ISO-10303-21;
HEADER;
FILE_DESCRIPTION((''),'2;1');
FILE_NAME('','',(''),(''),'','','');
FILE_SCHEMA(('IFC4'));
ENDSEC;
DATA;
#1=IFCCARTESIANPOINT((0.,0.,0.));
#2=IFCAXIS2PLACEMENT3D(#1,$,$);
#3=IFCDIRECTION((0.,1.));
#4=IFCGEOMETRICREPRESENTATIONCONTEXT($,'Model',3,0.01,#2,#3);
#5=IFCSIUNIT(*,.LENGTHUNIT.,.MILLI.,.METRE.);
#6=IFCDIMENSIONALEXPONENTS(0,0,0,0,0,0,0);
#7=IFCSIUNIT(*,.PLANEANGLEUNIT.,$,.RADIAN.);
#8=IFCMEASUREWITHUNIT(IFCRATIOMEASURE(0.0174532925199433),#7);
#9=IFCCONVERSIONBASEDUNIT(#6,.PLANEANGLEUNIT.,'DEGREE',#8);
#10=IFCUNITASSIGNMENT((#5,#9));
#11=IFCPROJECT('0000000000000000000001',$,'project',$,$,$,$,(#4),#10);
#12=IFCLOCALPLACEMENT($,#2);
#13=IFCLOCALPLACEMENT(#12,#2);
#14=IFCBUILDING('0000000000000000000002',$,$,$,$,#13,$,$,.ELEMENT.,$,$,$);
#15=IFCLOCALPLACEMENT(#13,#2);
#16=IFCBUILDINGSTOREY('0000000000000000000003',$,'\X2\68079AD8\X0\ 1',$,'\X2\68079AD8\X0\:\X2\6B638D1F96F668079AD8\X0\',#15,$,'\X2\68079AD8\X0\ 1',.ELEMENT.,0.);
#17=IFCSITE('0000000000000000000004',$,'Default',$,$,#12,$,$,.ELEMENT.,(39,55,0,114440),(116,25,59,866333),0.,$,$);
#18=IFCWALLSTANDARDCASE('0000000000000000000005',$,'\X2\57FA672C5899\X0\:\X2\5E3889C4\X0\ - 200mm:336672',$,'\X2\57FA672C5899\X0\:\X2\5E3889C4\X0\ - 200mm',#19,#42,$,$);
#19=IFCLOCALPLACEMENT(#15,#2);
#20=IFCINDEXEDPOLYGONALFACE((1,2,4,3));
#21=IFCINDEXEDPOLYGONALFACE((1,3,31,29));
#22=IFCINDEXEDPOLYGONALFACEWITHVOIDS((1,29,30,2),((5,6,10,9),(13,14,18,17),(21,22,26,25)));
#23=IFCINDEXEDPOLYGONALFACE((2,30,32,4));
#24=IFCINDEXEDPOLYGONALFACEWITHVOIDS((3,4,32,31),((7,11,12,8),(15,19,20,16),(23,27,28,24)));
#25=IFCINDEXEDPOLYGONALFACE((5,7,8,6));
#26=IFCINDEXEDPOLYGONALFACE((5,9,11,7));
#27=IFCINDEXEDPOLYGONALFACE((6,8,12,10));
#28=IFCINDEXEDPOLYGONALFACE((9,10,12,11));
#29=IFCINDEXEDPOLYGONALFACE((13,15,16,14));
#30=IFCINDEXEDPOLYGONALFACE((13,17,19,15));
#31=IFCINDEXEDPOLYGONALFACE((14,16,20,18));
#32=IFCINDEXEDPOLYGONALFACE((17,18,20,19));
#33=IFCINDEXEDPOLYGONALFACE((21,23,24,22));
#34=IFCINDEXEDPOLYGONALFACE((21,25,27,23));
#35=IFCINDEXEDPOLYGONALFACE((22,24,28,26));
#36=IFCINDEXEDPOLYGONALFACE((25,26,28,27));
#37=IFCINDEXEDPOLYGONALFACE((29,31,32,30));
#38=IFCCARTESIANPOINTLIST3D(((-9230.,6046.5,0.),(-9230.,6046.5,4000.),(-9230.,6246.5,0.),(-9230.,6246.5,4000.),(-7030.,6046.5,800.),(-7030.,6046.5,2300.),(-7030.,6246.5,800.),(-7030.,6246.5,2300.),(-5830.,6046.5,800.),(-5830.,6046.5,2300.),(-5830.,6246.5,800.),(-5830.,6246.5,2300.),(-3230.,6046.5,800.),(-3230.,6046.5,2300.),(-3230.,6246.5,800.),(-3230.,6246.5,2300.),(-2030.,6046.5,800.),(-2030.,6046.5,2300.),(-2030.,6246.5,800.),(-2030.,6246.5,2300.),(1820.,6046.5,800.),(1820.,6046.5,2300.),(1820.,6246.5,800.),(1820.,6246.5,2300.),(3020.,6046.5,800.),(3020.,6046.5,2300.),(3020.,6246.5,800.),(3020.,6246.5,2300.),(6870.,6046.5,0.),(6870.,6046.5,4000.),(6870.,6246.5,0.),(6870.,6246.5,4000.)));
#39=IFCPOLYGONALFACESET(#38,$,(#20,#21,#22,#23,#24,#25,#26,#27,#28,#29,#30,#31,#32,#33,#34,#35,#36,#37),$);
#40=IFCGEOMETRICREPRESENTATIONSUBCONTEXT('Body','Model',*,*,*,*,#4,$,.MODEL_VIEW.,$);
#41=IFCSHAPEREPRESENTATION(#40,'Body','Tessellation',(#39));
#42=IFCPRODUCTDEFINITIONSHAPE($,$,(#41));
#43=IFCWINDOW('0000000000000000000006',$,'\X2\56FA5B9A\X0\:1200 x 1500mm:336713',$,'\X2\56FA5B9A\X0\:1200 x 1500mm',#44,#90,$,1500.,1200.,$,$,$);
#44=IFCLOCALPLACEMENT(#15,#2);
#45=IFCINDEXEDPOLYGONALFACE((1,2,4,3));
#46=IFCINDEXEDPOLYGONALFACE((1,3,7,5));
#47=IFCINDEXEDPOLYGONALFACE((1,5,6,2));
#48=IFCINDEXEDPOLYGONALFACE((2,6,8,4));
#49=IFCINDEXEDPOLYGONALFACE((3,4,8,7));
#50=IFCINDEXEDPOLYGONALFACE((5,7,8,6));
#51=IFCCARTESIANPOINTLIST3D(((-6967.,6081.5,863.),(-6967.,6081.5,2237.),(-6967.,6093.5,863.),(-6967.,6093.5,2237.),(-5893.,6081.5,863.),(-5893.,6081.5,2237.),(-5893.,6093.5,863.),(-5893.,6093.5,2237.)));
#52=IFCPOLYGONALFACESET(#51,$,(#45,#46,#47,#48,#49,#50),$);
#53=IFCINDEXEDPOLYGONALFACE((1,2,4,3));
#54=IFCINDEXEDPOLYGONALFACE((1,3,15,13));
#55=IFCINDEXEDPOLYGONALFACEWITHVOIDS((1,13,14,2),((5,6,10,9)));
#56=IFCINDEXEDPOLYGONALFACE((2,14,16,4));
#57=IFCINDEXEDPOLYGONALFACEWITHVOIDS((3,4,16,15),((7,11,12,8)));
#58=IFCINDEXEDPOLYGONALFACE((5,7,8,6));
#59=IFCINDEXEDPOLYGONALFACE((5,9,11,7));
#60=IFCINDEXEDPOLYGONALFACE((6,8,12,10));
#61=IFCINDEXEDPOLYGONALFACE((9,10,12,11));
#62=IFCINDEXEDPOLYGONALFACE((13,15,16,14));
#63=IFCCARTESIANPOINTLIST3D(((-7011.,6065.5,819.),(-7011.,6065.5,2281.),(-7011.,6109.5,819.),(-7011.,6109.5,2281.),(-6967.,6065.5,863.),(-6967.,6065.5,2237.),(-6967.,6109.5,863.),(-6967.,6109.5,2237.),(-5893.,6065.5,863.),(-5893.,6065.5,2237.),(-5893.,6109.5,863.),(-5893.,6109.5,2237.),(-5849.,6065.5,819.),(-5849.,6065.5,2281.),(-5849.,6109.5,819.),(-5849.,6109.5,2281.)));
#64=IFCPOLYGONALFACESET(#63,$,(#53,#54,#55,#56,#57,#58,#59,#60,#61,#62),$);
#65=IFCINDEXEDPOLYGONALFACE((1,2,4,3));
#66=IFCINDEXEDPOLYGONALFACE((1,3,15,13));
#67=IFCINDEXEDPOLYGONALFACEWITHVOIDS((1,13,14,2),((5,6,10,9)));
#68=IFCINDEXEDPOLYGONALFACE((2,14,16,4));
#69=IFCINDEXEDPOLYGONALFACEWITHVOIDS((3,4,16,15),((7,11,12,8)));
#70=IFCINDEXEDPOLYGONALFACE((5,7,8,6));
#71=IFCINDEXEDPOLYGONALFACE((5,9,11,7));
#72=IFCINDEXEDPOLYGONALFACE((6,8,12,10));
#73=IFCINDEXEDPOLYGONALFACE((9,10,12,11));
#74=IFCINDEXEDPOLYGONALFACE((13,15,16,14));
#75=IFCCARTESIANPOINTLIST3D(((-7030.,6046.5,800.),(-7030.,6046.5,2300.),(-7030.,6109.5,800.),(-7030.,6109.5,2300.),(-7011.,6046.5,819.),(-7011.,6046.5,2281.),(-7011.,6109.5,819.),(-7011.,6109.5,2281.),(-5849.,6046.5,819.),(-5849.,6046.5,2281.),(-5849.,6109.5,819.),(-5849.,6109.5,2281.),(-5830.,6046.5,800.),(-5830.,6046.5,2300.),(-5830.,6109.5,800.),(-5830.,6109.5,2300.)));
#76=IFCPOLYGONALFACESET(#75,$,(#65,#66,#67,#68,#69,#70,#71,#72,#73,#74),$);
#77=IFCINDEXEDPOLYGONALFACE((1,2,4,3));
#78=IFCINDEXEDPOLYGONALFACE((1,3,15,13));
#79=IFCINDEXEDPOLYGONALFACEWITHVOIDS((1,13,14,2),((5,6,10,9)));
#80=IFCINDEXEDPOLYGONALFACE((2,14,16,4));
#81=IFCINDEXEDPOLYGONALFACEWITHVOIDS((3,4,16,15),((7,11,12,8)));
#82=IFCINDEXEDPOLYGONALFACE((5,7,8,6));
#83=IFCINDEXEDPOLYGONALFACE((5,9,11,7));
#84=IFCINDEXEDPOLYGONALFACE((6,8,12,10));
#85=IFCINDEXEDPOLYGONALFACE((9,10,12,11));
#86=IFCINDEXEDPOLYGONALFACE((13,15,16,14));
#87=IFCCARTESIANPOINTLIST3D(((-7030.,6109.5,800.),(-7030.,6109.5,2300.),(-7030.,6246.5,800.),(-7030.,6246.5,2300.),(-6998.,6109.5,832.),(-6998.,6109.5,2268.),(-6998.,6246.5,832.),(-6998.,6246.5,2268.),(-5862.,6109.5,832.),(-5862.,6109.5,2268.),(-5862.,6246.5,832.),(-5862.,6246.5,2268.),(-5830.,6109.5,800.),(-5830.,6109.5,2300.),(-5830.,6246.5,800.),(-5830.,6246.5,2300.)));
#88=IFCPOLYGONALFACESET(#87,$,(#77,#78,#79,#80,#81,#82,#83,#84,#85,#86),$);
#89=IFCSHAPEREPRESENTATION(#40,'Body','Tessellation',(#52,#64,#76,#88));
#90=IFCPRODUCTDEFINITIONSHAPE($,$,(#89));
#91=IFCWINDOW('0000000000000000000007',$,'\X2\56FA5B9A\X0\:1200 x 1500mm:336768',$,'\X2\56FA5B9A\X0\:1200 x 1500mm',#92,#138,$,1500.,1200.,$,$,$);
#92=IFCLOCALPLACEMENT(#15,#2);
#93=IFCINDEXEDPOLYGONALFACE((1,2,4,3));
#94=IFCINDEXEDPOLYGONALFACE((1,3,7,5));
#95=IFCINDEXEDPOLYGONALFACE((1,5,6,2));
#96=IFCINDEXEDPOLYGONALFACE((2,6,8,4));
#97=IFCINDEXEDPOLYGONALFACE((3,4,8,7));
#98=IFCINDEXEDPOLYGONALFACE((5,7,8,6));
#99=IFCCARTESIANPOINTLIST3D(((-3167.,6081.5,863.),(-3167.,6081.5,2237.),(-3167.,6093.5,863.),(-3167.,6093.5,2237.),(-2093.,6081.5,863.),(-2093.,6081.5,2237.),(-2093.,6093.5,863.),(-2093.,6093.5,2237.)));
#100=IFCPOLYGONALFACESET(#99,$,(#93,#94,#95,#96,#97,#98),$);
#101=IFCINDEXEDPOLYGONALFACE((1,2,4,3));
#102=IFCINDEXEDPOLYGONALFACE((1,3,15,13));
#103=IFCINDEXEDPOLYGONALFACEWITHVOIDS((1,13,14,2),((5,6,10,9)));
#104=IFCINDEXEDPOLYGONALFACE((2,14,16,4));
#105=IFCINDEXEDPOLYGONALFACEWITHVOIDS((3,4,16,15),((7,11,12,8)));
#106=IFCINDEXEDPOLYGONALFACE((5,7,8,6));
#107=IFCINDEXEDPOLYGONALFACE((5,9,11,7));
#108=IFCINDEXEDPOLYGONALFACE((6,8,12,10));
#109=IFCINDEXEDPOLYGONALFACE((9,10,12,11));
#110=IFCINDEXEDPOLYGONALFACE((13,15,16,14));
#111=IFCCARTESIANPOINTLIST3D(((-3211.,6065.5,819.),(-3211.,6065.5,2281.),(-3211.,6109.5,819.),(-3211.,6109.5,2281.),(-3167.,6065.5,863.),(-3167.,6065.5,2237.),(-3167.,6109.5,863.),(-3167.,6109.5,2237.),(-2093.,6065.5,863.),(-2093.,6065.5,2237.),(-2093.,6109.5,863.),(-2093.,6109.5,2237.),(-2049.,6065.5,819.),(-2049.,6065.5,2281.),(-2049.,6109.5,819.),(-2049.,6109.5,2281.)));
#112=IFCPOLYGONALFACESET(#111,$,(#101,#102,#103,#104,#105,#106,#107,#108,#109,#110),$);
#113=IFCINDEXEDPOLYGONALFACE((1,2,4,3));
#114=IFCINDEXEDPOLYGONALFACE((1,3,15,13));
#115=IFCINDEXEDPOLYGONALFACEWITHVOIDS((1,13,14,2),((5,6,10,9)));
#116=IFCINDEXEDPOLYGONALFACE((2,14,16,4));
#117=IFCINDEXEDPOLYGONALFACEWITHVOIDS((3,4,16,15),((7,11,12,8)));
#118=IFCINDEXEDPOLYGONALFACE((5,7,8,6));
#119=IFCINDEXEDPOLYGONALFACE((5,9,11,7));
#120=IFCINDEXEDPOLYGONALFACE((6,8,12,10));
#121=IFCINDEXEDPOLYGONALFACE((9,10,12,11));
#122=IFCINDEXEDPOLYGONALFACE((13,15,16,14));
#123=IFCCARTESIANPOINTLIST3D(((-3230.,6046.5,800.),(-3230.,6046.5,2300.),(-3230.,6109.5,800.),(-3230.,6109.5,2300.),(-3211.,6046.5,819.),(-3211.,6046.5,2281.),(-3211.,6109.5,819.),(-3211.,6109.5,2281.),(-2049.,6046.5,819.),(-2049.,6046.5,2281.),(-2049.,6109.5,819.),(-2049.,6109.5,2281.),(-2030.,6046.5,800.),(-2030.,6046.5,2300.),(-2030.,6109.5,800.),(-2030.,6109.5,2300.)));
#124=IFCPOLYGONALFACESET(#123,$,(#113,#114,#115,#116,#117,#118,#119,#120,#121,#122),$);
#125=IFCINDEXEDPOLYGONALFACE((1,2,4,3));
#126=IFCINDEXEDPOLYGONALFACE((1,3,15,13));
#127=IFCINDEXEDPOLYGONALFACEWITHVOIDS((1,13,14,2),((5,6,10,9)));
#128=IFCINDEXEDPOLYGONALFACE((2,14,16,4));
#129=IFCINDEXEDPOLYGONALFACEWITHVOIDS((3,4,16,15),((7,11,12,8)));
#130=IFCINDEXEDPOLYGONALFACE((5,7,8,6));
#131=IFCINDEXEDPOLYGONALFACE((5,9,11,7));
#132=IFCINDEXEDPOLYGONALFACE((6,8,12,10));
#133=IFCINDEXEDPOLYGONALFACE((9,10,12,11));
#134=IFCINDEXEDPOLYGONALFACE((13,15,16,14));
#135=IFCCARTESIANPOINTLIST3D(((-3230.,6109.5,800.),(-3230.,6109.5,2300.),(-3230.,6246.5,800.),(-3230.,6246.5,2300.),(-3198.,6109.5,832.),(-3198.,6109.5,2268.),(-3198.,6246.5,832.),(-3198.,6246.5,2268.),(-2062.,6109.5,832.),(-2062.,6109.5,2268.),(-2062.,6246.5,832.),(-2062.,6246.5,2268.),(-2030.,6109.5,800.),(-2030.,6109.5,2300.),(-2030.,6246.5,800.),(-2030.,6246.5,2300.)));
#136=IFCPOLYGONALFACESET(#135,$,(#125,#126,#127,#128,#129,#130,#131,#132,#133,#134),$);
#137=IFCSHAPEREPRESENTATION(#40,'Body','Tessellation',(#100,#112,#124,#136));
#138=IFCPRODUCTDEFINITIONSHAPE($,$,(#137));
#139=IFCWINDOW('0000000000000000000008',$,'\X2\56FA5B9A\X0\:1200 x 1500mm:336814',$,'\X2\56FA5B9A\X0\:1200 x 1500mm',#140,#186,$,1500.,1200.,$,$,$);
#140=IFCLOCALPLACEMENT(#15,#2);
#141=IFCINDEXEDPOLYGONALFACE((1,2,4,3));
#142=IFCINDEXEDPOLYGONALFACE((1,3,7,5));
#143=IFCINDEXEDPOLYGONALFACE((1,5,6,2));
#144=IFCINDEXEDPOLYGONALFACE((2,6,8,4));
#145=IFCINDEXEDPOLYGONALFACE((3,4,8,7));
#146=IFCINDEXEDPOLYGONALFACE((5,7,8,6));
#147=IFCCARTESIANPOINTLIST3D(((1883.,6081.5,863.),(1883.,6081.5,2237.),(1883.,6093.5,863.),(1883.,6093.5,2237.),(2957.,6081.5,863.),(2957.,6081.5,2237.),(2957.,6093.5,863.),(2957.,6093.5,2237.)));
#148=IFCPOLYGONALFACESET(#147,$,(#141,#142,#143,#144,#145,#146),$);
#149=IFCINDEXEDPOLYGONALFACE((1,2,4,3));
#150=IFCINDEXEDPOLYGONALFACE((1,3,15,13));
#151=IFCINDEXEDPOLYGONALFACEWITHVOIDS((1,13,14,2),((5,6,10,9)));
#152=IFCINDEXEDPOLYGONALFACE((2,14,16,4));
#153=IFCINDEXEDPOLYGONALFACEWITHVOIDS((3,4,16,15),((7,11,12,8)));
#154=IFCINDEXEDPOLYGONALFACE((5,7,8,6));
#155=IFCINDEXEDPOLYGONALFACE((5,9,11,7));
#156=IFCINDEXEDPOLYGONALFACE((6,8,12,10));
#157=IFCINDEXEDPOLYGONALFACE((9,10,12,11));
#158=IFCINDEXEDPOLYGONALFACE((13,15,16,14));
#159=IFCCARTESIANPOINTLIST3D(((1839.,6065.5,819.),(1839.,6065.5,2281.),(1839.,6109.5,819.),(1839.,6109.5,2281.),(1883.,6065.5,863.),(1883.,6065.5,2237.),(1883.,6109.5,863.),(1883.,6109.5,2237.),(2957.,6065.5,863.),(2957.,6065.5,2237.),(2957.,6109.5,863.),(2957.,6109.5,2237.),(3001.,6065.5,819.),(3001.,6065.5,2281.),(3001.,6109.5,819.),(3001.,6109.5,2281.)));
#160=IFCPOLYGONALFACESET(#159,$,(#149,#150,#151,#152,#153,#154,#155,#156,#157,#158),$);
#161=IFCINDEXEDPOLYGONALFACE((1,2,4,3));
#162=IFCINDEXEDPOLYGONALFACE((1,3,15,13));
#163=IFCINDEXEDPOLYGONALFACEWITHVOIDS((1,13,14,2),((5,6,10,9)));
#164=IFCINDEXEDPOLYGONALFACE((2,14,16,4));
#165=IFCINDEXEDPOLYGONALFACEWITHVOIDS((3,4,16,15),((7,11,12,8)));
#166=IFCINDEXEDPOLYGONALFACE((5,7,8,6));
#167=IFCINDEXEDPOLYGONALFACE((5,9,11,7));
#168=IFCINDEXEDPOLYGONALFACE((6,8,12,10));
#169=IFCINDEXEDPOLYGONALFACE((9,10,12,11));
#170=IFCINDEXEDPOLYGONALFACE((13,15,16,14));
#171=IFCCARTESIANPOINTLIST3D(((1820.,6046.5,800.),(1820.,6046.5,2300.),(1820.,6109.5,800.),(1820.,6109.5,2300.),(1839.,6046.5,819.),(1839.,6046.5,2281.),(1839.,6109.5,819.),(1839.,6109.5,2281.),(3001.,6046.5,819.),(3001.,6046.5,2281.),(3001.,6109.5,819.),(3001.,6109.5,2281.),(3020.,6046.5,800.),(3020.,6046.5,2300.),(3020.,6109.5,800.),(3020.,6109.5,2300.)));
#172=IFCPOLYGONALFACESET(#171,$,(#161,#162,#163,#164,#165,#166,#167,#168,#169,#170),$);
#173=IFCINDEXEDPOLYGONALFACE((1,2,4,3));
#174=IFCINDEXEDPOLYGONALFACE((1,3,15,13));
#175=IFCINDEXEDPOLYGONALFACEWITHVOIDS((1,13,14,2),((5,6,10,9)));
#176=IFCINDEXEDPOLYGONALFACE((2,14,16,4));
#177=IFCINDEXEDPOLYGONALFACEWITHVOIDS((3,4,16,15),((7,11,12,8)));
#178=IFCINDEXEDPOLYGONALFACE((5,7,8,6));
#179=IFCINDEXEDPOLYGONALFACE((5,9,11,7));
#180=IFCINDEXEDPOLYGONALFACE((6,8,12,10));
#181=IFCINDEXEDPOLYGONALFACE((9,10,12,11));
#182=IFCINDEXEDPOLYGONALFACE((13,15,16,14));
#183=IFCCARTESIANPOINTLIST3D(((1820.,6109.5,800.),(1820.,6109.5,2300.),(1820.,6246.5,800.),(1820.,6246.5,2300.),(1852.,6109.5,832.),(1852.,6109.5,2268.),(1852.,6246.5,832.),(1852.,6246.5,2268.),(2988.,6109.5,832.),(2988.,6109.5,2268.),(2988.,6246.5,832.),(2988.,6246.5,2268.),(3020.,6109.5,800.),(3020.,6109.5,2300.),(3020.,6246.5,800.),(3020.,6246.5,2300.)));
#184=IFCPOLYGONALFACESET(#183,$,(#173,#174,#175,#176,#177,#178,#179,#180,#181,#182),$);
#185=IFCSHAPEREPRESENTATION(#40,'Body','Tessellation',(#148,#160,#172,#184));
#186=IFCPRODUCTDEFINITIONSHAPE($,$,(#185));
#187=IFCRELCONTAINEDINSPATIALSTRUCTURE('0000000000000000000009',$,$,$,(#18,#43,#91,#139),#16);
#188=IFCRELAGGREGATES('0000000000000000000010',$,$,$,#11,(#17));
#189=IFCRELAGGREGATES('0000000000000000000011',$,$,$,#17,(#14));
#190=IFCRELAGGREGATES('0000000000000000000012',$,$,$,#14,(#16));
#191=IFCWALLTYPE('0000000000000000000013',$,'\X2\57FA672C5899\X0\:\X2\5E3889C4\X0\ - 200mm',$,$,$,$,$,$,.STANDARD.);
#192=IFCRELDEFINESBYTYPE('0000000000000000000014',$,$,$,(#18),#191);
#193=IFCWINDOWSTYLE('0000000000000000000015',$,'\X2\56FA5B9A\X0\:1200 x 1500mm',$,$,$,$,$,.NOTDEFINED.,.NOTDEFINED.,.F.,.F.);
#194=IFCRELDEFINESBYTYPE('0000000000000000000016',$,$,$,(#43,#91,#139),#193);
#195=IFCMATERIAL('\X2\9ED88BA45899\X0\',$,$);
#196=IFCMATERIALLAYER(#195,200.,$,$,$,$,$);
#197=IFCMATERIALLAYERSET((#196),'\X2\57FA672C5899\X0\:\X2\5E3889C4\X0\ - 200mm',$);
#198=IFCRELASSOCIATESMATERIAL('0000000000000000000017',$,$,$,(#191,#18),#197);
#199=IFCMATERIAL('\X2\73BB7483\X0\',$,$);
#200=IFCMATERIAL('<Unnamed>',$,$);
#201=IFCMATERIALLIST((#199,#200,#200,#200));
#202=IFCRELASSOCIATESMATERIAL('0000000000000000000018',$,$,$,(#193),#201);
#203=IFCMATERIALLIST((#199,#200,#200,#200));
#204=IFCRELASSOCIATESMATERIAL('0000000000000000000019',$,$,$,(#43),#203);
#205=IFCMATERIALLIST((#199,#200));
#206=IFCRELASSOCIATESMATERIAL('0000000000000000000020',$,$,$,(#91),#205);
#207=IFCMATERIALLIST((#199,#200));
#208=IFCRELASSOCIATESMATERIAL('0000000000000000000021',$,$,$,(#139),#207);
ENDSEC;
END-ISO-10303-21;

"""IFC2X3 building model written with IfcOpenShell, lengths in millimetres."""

from ifc_helpers import new_model, entity, si_unit, converted_unit, direction, frame, frame_2d, origin, place, context, subcontext, project, spatial, polyline, rectangle, outline, extrude, source, transform, mapped, material, material_list, layer, layer_set, layer_usage, type_object, type_shapes, element, fill, save


model = new_model("IFC2X3")

# Units and contexts
model_context = context("Model", 3, precision=0.01, world=origin(), true_north=direction((0.0, 1.0)))
body_context = subcontext(model_context, "Body", "Model", "MODEL_VIEW")
ifc_project = project(units=[si_unit("LENGTHUNIT", "METRE", prefix="MILLI"), converted_unit("PLANEANGLEUNIT", "DEGREE", entity("IfcRatioMeasure", 0.0174532925199433), si_unit("PLANEANGLEUNIT", "RADIAN"), dimensions=[0, 0, 0, 0, 0, 0, 0])], contexts=[model_context])

# Site, building, storey
site_placement = place(None, origin())
site = spatial("IfcSite", under=ifc_project, at=site_placement, Name="Default", CompositionType="ELEMENT", RefLatitude=(39, 55, 0, 114440), RefLongitude=(116, 25, 59, 866333), RefElevation=0.0)
building_placement = place(site_placement, origin())
building = spatial("IfcBuilding", under=site, at=building_placement, CompositionType="ELEMENT")
storey_placement = place(building_placement, origin())
storey = spatial("IfcBuildingStorey", under=building, at=storey_placement, Name="标高 1", ObjectType="标高:正负零标高", LongName="标高 1", CompositionType="ELEMENT", Elevation=0.0)

# Shared definitions
ifc_material_1 = material(Name="默认墙")
ifc_layer = layer(ifc_material_1, 200.0)
ifc_layer_set = layer_set([ifc_layer], Name="基本墙:常规 - 200mm")
wall_type = type_object("IfcWallType", Name="基本墙:常规 - 200mm", PredefinedType="STANDARD", material=ifc_layer_set)
ifc_material_2 = material(Name="玻璃")
ifc_material_3 = material(Name="<Unnamed>")

# Shared definitions
ifc_material_list_1 = material_list([ifc_material_2, ifc_material_3, ifc_material_3, ifc_material_3])
window_style_1 = type_object("IfcWindowStyle", Name="固定:1200 x 1500mm", ConstructionType="NOTDEFINED", OperationType="NOTDEFINED", ParameterTakesPrecedence=False, Sizeable=False, material=ifc_material_list_1)
shared_shape_1 = source(origin(), body_context, "Body", "SweptSolid", [
    extrude(rectangle(XDim=12.0, YDim=1074.0, at=frame_2d((0.0, 0.0), x_axis=(1.0, 0.0))), frame((600.0, 159.0, 63.0), z_axis=(0.0, 0.0, 1.0), x_axis=(0.0, -1.0, 0.0)), (0.0, 0.0, 1.0), 1374.0),
    extrude(outline(polyline([(-581.0, -731.0), (581.0, -731.0), (581.0, 731.0), (-581.0, 731.0), (-581.0, -731.0)]), holes=[polyline([(-537.0, -687.0), (-537.0, 687.0), (537.0, 687.0), (537.0, -687.0), (-537.0, -687.0)])]), frame((600.0, 137.0, 750.0), z_axis=(0.0, 1.0, 0.0), x_axis=(1.0, 0.0, 0.0)), (0.0, 0.0, 1.0), 44.0),
    extrude(outline(polyline([(-600.0, -750.0), (600.0, -750.0), (600.0, 750.0), (-600.0, 750.0), (-600.0, -750.0)]), holes=[polyline([(-581.0, -731.0), (-581.0, 731.0), (581.0, 731.0), (581.0, -731.0), (-581.0, -731.0)])]), frame((600.0, 137.0, 750.0), z_axis=(0.0, 1.0, 0.0), x_axis=(1.0, 0.0, 0.0)), (0.0, 0.0, 1.0), 63.0),
    extrude(outline(polyline([(-600.0, -750.0), (600.0, -750.0), (600.0, 750.0), (-600.0, 750.0), (-600.0, -750.0)]), holes=[polyline([(-568.0, -718.0), (-568.0, 718.0), (568.0, 718.0), (568.0, -718.0), (-568.0, -718.0)])]), frame((600.0, 0.0, 750.0), z_axis=(0.0, 1.0, 0.0), x_axis=(1.0, 0.0, 0.0)), (0.0, 0.0, 1.0), 137.0),
])
type_shapes(window_style_1, [shared_shape_1])

# Wall, openings, windows
ifc_layer_usage_1 = layer_usage(ifc_layer_set, "AXIS2", "NEGATIVE", 100.0)
wall_1_placement = place(storey_placement, frame((6870.0, 6146.5, 0.0), z_axis=(0.0, 0.0, 1.0), x_axis=(-1.0, 0.0, 0.0)))
wall_1 = element("IfcWallStandardCase", 1, at=wall_1_placement, inside=storey, type_object=wall_type, material=ifc_layer_usage_1, Name="基本墙:常规 - 200mm:336672", ObjectType="基本墙:常规 - 200mm", context=body_context, shape_type="SweptSolid", body=[
    extrude(rectangle(XDim=16100.0, YDim=200.0, at=frame_2d((8050.0, 0.0), x_axis=(-1.0, 0.0))), origin(), (0.0, 0.0, 1.0), 4000.0),
])
opening_1_placement = place(wall_1_placement, frame((12700.0, -100.0, 800.0)))
opening_1 = element("IfcOpeningElement", 2, at=opening_1_placement, cuts=wall_1, ObjectType="Opening", context=body_context, shape_type="SweptSolid", body=[
    extrude(rectangle(XDim=1500.0, YDim=1200.0, at=frame_2d((750.0, 600.0), x_axis=(1.0, 0.0))), frame((0.0, 0.0, 0.0), z_axis=(0.0, 1.0, 0.0), x_axis=(0.0, 0.0, 1.0)), (0.0, 0.0, 1.0), 200.0),
])
opening_2_placement = place(wall_1_placement, frame((8900.0, -100.0, 800.0)))
opening_2 = element("IfcOpeningElement", 3, at=opening_2_placement, cuts=wall_1, ObjectType="Opening", context=body_context, shape_type="SweptSolid", body=[
    extrude(rectangle(XDim=1500.0, YDim=1200.0, at=frame_2d((750.0, 600.0), x_axis=(1.0, 0.0))), frame((0.0, 0.0, 0.0), z_axis=(0.0, 1.0, 0.0), x_axis=(0.0, 0.0, 1.0)), (0.0, 0.0, 1.0), 200.0),
])
opening_3_placement = place(wall_1_placement, frame((3850.0, -100.0, 800.0)))
opening_3 = element("IfcOpeningElement", 4, at=opening_3_placement, cuts=wall_1, ObjectType="Opening", context=body_context, shape_type="SweptSolid", body=[
    extrude(rectangle(XDim=1500.0, YDim=1200.0, at=frame_2d((750.0, 600.0), x_axis=(1.0, 0.0))), frame((0.0, 0.0, 0.0), z_axis=(0.0, 1.0, 0.0), x_axis=(0.0, 0.0, 1.0)), (0.0, 0.0, 1.0), 200.0),
])
ifc_material_list_2 = material_list([ifc_material_2, ifc_material_3, ifc_material_3, ifc_material_3])
window_1_placement = place(opening_1_placement, origin())
window_1 = element("IfcWindow", 5, at=window_1_placement, inside=storey, type_object=window_style_1, material=ifc_material_list_2, Name="固定:1200 x 1500mm:336713", ObjectType="固定:1200 x 1500mm", OverallHeight=1500.0, OverallWidth=1200.0, context=body_context, shape_type="MappedRepresentation", body=[
    mapped(shared_shape_1, transform((0.0, 0.0, 0.0), scale=1.0)),
])
fill(opening_1, window_1)
ifc_material_list_3 = material_list([ifc_material_2, ifc_material_3])
window_2_placement = place(opening_2_placement, origin())
window_2 = element("IfcWindow", 6, at=window_2_placement, inside=storey, type_object=window_style_1, material=ifc_material_list_3, Name="固定:1200 x 1500mm:336768", ObjectType="固定:1200 x 1500mm", OverallHeight=1500.0, OverallWidth=1200.0, context=body_context, shape_type="MappedRepresentation", body=[
    mapped(shared_shape_1, transform((0.0, 0.0, 0.0), scale=1.0)),
])
fill(opening_2, window_2)
ifc_material_list_4 = material_list([ifc_material_2, ifc_material_3])
window_3_placement = place(opening_3_placement, origin())
window_3 = element("IfcWindow", 7, at=window_3_placement, inside=storey, type_object=window_style_1, material=ifc_material_list_4, Name="固定:1200 x 1500mm:336814", ObjectType="固定:1200 x 1500mm", OverallHeight=1500.0, OverallWidth=1200.0, context=body_context, shape_type="MappedRepresentation", body=[
    mapped(shared_shape_1, transform((0.0, 0.0, 0.0), scale=1.0)),
])
fill(opening_3, window_3)

save(model, "model.ifc")
